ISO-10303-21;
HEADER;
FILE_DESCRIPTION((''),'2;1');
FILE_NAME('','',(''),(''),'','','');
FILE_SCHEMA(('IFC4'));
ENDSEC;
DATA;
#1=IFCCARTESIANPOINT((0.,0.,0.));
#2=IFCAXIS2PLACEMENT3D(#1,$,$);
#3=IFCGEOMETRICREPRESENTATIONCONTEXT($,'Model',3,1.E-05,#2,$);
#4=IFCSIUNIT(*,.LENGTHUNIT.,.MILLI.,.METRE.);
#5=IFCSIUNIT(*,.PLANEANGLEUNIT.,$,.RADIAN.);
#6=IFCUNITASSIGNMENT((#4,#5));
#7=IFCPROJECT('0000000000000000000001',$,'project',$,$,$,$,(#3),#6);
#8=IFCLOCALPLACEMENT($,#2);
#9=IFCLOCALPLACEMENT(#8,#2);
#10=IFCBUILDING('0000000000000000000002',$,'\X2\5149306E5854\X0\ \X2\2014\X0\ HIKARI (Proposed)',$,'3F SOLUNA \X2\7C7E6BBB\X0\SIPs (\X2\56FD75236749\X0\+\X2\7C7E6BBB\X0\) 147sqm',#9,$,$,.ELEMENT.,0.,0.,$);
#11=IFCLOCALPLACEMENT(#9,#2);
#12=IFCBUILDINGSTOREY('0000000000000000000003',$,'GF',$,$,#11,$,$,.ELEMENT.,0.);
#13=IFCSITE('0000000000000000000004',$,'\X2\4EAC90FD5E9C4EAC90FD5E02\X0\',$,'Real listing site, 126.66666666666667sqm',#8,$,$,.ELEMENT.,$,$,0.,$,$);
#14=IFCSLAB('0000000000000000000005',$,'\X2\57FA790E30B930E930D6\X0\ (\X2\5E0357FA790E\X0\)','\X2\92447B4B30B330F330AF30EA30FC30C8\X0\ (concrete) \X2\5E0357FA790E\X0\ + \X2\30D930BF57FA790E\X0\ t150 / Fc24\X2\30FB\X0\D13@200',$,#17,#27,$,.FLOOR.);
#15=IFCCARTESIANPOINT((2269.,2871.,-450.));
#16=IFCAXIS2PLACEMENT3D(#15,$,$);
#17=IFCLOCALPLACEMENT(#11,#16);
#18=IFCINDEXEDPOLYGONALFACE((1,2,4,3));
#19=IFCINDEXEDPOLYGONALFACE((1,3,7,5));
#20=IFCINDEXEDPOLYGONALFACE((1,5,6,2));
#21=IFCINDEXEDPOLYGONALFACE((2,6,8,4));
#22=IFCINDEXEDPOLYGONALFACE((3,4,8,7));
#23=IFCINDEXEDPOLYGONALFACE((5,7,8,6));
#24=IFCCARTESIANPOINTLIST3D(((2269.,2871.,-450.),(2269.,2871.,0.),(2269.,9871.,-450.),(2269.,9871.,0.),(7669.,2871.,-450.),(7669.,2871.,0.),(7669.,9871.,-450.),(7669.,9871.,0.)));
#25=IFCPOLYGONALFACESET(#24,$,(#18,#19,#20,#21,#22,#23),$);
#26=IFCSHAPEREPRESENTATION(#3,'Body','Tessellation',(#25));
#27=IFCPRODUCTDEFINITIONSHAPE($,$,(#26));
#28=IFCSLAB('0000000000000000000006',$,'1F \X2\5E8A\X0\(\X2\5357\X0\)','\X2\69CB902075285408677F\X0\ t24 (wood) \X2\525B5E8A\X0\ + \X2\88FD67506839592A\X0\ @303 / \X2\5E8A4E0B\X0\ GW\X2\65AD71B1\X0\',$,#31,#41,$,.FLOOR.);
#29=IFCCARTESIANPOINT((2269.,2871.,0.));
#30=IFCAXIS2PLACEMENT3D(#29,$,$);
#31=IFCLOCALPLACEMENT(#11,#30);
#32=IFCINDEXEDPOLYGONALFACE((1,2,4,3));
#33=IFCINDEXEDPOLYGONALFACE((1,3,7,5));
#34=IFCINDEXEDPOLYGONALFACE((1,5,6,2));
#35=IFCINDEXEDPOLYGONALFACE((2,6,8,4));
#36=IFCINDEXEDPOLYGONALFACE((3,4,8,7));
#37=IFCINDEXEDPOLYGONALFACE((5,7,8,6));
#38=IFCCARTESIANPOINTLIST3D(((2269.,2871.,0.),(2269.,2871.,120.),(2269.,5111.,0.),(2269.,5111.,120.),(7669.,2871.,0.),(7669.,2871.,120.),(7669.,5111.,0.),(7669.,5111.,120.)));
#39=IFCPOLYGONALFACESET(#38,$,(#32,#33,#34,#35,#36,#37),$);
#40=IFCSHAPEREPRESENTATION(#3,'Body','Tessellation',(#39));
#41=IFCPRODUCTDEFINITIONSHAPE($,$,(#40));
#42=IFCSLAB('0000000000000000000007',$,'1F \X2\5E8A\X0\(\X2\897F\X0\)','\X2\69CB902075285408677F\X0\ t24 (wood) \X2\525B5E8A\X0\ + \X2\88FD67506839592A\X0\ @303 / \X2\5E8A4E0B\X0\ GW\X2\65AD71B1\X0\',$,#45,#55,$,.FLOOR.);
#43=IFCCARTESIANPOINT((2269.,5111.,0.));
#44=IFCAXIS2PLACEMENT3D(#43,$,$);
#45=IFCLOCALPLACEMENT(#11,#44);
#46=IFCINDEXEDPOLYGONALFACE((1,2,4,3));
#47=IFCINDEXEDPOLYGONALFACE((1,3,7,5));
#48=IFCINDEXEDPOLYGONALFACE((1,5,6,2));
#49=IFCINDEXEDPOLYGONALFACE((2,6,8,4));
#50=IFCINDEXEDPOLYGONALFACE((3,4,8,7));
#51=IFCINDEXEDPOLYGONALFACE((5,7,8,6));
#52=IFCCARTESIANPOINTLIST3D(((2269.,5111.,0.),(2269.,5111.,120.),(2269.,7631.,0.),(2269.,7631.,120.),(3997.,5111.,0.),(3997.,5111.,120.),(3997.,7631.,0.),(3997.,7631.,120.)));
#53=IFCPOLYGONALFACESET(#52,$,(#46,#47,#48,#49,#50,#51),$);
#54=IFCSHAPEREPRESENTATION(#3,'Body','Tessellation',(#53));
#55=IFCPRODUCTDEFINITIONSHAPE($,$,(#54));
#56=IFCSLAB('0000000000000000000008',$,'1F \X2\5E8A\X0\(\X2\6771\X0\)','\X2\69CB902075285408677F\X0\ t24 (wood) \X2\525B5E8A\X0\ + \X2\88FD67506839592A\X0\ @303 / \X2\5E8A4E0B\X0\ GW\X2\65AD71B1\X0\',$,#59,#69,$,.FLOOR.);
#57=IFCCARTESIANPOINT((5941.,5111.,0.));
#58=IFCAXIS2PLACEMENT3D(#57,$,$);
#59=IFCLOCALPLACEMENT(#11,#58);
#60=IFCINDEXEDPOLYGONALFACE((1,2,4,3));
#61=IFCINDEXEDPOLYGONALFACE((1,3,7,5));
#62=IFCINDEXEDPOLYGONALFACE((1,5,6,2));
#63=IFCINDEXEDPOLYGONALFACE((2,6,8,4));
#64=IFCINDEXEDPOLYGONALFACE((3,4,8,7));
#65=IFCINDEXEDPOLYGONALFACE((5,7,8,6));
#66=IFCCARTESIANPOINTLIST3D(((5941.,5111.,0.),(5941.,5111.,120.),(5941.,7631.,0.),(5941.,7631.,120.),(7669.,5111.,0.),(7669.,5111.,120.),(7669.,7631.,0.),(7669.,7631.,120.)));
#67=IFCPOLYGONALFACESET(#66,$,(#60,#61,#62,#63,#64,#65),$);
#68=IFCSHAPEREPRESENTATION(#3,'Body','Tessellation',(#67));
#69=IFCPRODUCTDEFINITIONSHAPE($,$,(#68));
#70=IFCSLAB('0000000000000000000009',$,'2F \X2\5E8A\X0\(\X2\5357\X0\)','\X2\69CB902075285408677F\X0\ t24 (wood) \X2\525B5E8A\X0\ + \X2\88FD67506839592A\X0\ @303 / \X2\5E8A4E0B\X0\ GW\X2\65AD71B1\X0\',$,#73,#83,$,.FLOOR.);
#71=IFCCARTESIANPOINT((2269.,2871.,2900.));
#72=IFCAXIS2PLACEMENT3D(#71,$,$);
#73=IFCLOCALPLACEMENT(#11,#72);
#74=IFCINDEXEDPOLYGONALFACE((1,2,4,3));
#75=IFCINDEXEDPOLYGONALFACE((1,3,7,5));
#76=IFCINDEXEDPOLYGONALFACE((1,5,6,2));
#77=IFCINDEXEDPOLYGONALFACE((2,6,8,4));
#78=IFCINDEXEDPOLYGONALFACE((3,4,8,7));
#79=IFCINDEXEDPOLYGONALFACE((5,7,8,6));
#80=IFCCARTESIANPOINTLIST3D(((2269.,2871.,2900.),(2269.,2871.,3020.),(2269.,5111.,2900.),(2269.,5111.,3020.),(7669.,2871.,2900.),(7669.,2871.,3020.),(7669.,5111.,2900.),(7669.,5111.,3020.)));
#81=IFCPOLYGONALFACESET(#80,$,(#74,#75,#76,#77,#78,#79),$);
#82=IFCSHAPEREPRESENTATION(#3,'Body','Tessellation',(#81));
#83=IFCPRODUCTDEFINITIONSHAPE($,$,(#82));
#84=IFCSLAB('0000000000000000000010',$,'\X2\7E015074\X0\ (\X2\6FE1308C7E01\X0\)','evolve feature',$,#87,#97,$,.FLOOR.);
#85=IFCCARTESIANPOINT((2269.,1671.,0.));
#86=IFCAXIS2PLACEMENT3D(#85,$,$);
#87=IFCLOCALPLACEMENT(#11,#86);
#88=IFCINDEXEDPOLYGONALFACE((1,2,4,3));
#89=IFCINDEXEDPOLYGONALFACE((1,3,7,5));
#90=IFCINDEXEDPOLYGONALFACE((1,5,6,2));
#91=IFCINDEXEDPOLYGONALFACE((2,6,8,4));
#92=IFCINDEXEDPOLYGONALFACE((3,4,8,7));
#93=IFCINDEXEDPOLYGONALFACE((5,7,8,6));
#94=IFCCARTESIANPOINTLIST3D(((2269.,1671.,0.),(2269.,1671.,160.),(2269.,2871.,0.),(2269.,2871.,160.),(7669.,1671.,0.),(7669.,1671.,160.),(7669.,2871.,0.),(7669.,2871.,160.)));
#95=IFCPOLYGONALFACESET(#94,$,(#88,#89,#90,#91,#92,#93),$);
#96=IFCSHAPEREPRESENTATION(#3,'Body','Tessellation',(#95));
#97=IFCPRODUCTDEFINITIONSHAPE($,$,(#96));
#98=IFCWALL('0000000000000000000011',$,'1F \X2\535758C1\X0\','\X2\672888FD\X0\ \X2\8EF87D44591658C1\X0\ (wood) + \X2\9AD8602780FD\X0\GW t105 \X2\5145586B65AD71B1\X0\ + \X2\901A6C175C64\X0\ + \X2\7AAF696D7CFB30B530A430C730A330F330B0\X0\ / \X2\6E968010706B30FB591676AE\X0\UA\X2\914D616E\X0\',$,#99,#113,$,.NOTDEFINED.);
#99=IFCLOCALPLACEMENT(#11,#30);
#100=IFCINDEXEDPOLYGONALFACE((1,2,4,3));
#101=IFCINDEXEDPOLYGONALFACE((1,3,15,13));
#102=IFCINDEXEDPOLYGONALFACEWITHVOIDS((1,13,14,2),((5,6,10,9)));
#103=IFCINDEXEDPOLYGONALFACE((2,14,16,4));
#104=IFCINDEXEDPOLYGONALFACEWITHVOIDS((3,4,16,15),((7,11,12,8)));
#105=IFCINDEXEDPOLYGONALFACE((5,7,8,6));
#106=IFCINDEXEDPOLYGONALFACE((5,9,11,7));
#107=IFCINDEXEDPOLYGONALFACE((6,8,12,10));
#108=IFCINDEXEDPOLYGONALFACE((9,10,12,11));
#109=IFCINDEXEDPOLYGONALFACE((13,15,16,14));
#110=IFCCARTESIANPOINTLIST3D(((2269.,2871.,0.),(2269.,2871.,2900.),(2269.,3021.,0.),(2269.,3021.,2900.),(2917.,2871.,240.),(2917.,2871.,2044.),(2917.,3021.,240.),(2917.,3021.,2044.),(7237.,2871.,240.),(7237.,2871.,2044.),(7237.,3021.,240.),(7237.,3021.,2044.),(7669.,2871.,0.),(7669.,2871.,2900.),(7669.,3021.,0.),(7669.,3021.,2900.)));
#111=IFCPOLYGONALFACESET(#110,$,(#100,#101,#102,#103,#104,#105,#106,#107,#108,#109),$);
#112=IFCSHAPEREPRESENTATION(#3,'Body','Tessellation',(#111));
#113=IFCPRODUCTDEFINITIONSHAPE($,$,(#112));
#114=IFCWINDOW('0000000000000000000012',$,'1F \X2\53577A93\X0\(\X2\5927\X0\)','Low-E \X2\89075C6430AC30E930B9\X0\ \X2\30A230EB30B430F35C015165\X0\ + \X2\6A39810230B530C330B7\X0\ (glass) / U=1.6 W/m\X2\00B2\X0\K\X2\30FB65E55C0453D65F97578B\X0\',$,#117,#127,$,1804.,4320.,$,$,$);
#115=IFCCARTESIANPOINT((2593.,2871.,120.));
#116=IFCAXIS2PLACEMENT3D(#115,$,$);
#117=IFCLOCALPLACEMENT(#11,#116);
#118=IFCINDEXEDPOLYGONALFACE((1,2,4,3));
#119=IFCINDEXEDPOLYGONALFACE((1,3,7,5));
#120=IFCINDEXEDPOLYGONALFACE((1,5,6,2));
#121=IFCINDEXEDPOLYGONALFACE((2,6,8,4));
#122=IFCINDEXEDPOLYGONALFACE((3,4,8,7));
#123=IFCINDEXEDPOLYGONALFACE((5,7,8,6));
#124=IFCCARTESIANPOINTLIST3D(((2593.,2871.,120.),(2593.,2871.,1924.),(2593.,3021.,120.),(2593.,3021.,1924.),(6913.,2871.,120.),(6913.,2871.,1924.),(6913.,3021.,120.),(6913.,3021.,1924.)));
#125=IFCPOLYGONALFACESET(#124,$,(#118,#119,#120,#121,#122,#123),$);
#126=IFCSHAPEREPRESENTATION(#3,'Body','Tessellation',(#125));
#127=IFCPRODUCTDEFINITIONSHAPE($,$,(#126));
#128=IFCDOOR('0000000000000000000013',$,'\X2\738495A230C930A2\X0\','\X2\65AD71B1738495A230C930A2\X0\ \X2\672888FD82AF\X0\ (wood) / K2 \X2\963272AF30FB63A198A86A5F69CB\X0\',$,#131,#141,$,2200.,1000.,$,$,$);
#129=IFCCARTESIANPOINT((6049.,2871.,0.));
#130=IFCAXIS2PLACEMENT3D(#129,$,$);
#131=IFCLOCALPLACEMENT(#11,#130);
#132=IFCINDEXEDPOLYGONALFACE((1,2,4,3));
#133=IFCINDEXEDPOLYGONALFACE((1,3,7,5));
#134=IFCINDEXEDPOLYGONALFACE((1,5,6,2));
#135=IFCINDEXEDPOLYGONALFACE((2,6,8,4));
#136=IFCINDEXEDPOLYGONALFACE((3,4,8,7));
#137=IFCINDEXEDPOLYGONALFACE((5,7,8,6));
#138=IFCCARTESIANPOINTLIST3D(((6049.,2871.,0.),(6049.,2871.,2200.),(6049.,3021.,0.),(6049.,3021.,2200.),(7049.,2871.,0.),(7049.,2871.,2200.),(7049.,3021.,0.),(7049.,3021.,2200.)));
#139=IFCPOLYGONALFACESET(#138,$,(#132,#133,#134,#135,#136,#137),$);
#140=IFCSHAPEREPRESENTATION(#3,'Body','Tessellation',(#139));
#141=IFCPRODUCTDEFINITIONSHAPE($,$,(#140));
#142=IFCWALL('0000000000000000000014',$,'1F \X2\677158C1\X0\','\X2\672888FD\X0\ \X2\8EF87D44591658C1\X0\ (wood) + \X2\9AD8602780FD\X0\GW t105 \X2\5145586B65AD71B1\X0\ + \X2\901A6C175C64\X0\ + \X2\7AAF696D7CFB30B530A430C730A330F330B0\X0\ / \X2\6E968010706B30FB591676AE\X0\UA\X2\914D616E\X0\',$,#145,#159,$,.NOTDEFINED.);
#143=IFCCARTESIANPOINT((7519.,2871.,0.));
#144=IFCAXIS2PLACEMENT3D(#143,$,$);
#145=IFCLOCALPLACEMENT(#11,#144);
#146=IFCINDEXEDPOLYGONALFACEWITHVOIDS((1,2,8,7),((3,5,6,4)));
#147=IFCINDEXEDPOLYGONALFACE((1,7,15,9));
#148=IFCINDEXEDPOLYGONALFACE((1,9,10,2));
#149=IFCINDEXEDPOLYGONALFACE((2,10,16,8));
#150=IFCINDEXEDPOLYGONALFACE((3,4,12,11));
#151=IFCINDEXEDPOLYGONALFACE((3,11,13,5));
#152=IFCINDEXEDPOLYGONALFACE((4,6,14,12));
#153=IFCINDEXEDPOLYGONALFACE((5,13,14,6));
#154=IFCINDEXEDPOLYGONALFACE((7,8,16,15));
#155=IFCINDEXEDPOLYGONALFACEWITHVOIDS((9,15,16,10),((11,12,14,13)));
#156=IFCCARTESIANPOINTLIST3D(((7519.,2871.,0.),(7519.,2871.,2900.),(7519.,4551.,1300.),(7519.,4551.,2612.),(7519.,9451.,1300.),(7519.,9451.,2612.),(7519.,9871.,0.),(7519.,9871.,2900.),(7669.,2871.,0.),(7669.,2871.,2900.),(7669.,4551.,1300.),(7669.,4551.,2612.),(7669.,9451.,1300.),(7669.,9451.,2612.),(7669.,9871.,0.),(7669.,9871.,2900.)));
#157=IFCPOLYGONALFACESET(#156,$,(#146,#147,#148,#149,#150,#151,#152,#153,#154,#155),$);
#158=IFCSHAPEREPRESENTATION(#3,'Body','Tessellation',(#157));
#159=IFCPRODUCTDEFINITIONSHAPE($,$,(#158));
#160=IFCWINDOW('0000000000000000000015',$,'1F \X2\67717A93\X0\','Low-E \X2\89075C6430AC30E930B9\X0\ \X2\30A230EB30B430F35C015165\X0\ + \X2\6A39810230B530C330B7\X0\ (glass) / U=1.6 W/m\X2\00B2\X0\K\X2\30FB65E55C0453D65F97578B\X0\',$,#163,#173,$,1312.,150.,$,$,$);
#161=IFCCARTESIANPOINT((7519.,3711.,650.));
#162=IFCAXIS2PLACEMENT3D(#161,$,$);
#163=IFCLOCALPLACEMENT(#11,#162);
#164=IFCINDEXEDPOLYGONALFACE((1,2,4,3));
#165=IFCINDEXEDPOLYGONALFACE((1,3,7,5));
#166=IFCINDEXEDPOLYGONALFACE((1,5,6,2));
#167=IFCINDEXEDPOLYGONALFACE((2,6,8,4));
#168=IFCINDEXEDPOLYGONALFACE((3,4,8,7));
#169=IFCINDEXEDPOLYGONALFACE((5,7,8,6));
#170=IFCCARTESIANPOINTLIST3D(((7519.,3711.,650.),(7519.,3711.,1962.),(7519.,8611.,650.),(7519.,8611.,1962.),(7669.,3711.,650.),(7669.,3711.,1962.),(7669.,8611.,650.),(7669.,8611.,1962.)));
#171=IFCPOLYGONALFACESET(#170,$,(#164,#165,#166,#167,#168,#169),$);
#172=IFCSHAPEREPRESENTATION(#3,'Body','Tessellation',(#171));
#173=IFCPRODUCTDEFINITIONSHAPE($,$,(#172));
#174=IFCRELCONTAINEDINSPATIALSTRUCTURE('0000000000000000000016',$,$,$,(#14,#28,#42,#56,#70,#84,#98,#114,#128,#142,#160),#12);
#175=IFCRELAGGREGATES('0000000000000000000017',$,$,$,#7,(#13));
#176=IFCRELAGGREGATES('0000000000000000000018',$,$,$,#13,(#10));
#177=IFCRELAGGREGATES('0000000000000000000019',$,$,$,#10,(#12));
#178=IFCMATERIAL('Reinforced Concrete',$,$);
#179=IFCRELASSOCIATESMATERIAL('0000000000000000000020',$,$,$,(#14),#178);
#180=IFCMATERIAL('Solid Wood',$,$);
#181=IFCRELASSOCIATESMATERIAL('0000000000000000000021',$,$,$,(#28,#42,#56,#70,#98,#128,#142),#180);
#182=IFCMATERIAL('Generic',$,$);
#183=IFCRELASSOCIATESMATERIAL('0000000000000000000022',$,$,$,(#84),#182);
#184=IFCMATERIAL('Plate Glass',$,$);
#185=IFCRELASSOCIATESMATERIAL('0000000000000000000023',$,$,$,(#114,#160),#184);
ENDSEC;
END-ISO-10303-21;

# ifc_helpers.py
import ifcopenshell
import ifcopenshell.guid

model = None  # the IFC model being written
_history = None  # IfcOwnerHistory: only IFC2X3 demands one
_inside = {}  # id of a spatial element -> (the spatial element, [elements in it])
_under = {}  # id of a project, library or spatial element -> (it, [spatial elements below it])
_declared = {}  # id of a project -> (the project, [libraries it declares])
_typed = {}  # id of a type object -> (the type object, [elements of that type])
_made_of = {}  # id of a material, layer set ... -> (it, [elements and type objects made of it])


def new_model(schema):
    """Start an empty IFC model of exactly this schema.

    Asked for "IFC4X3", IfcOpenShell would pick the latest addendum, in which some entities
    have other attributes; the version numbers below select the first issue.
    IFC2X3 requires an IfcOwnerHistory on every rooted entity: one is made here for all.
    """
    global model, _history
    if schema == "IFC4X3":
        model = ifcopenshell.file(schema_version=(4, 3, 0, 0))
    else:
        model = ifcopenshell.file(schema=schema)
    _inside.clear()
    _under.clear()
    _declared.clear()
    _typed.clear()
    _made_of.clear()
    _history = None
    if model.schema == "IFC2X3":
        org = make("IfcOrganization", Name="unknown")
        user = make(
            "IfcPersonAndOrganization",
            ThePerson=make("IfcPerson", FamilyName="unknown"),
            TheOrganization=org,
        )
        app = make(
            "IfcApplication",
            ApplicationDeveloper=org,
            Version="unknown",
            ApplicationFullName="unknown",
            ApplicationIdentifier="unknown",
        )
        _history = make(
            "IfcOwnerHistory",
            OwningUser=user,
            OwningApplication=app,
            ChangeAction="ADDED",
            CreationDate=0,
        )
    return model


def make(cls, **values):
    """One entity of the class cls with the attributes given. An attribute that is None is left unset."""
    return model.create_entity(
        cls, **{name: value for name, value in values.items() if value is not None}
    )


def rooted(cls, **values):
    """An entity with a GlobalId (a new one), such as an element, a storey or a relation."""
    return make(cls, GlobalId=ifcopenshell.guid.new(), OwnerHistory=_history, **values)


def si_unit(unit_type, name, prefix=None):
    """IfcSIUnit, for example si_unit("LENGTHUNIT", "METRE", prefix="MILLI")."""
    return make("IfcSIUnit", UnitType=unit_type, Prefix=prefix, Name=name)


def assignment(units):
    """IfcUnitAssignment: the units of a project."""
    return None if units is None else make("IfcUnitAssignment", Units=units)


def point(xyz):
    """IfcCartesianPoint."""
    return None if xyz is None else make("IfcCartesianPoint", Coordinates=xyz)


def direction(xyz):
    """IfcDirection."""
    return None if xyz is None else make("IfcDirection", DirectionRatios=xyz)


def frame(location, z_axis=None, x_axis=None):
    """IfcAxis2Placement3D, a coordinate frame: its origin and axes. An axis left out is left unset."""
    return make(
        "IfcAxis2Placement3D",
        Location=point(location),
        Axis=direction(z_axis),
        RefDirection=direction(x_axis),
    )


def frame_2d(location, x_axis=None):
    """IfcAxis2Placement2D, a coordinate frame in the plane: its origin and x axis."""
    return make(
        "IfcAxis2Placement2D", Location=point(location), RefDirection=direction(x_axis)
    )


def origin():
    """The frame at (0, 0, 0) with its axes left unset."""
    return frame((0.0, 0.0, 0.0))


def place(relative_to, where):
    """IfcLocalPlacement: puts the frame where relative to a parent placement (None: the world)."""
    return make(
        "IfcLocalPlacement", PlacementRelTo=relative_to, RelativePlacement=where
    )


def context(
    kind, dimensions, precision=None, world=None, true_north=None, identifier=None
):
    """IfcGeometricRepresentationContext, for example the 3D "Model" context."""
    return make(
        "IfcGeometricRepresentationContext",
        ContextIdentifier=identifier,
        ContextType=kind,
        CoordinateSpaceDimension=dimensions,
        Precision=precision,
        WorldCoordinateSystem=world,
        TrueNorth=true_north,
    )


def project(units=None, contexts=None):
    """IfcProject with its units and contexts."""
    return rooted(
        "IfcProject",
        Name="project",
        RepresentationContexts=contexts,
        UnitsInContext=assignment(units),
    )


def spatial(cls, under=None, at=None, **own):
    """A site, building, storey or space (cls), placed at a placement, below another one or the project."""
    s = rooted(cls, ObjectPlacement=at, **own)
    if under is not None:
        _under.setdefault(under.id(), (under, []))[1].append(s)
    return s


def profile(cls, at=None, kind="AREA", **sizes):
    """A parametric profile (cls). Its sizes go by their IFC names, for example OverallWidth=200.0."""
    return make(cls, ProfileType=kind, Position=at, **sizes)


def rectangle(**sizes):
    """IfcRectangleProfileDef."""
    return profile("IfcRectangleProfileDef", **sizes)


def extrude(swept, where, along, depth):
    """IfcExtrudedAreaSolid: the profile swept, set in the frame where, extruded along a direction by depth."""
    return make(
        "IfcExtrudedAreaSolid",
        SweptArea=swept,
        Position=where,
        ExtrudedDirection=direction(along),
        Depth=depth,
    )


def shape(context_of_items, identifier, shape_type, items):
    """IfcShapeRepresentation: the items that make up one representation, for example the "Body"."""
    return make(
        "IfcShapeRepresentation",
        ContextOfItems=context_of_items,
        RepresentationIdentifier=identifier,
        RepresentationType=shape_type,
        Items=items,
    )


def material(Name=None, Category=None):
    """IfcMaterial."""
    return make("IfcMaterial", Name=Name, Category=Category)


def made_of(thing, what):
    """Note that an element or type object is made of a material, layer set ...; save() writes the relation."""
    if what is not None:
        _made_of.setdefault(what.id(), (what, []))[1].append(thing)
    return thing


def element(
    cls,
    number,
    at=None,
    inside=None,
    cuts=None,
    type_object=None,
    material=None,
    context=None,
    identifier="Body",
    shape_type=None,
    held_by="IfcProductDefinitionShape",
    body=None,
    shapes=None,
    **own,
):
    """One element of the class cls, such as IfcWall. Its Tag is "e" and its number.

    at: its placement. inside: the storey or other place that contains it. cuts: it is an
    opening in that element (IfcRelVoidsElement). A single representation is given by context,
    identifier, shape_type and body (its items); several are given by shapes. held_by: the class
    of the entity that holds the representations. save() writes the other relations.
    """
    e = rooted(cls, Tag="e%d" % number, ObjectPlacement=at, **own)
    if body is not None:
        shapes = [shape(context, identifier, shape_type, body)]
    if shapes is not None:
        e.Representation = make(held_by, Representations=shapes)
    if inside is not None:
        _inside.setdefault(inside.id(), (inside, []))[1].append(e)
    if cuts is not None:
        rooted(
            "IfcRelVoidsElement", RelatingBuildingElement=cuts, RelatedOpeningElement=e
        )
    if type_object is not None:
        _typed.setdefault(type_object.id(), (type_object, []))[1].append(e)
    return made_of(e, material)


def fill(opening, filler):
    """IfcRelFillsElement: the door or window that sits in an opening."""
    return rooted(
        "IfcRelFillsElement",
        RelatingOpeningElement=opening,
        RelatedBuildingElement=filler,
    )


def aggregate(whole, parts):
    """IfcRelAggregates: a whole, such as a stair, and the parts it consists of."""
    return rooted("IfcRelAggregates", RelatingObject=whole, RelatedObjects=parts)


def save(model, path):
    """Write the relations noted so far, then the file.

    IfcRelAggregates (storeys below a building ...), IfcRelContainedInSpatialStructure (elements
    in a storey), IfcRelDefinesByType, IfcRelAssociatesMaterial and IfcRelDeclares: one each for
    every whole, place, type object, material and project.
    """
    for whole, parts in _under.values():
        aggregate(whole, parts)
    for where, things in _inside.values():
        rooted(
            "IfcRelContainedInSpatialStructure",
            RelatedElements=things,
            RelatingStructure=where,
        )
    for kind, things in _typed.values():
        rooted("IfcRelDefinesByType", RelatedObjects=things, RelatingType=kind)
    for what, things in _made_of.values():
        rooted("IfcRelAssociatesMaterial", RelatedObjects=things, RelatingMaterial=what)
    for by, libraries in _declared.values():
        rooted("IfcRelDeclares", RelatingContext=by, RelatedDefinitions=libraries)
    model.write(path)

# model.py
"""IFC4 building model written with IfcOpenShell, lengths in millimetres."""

from ifc_helpers import new_model, si_unit, frame, frame_2d, origin, place, context, project, spatial, rectangle, extrude, material, element, fill, save


model = new_model("IFC4")

# Units and contexts
model_context = context("Model", 3, precision=1e-05, world=origin())
ifc_project = project(units=[si_unit("LENGTHUNIT", "METRE", prefix="MILLI"), si_unit("PLANEANGLEUNIT", "RADIAN")], contexts=[model_context])

# Site, building, storey
site_placement = place(None, origin())
site = spatial("IfcSite", under=ifc_project, at=site_placement, Name="京都府京都市", ObjectType="Real listing site, 126.66666666666667sqm", CompositionType="ELEMENT", RefElevation=0.0)
building_placement = place(site_placement, origin())
building = spatial("IfcBuilding", under=site, at=building_placement, Name="光の塔 — HIKARI (Proposed)", ObjectType="3F SOLUNA 籾殻SIPs (国産杉+籾殻) 147sqm", CompositionType="ELEMENT", ElevationOfRefHeight=0.0, ElevationOfTerrain=0.0)
storey_placement = place(building_placement, origin())
storey = spatial("IfcBuildingStorey", under=building, at=storey_placement, Name="GF", CompositionType="ELEMENT", Elevation=0.0)

# Slabs
ifc_material_1 = material(Name="Reinforced Concrete")
slab_1_placement = place(storey_placement, frame((2269.0, 2871.0, -450.0)))
element("IfcSlab", 1, at=slab_1_placement, inside=storey, material=ifc_material_1, Name="基礎スラブ (布基礎)", Description="鉄筋コンクリート (concrete) 布基礎 + ベタ基礎 t150 / Fc24・D13@200", PredefinedType="FLOOR", context=model_context, shape_type="SweptSolid", body=[
    extrude(rectangle(XDim=5400.0, YDim=7000.0, at=frame_2d((2700.0, 3500.0))), frame((2269.0, 2871.0, -450.0)), (0.0, 0.0, 1.0), 450.0),
])
ifc_material_2 = material(Name="Solid Wood")
slab_2_placement = place(storey_placement, frame((2269.0, 2871.0, 0.0)))
element("IfcSlab", 2, at=slab_2_placement, inside=storey, material=ifc_material_2, Name="1F 床(南)", Description="構造用合板 t24 (wood) 剛床 + 製材根太 @303 / 床下 GW断熱", PredefinedType="FLOOR", context=model_context, shape_type="SweptSolid", body=[
    extrude(rectangle(XDim=5400.0, YDim=2240.0, at=frame_2d((2700.0, 1120.0))), frame((2269.0, 2871.0, 0.0)), (0.0, 0.0, 1.0), 120.0),
])
slab_3_placement = place(storey_placement, frame((2269.0, 5111.0, 0.0)))
element("IfcSlab", 3, at=slab_3_placement, inside=storey, material=ifc_material_2, Name="1F 床(西)", Description="構造用合板 t24 (wood) 剛床 + 製材根太 @303 / 床下 GW断熱", PredefinedType="FLOOR", context=model_context, shape_type="SweptSolid", body=[
    extrude(rectangle(XDim=1728.0, YDim=2520.0, at=frame_2d((864.0, 1260.0))), frame((2269.0, 5111.0, 0.0)), (0.0, 0.0, 1.0), 120.0),
])
slab_4_placement = place(storey_placement, frame((5941.0, 5111.0, 0.0)))
element("IfcSlab", 4, at=slab_4_placement, inside=storey, material=ifc_material_2, Name="1F 床(東)", Description="構造用合板 t24 (wood) 剛床 + 製材根太 @303 / 床下 GW断熱", PredefinedType="FLOOR", context=model_context, shape_type="SweptSolid", body=[
    extrude(rectangle(XDim=1728.0, YDim=2520.0, at=frame_2d((864.0, 1260.0))), frame((5941.0, 5111.0, 0.0)), (0.0, 0.0, 1.0), 120.0),
])
slab_5_placement = place(storey_placement, frame((2269.0, 2871.0, 2900.0)))
element("IfcSlab", 5, at=slab_5_placement, inside=storey, material=ifc_material_2, Name="2F 床(南)", Description="構造用合板 t24 (wood) 剛床 + 製材根太 @303 / 床下 GW断熱", PredefinedType="FLOOR", context=model_context, shape_type="SweptSolid", body=[
    extrude(rectangle(XDim=5400.0, YDim=2240.0, at=frame_2d((2700.0, 1120.0))), frame((2269.0, 2871.0, 2900.0)), (0.0, 0.0, 1.0), 120.0),
])
ifc_material_3 = material(Name="Generic")
slab_6_placement = place(storey_placement, frame((2269.0, 1671.0, 0.0)))
element("IfcSlab", 6, at=slab_6_placement, inside=storey, material=ifc_material_3, Name="縁側 (濡れ縁)", Description="evolve feature", PredefinedType="FLOOR", context=model_context, shape_type="SweptSolid", body=[
    extrude(rectangle(XDim=5400.0, YDim=1200.0, at=frame_2d((2700.0, 600.0))), frame((2269.0, 1671.0, 0.0)), (0.0, 0.0, 1.0), 160.0),
])

# Wall, openings, window, door
wall_1_placement = place(storey_placement, frame((2269.0, 2871.0, 0.0)))
wall_1 = element("IfcWall", 7, at=wall_1_placement, inside=storey, material=ifc_material_2, Name="1F 南壁", Description="木製 軸組外壁 (wood) + 高性能GW t105 充填断熱 + 通気層 + 窯業系サイディング / 準耐火・外皮UA配慮", PredefinedType="NOTDEFINED", context=model_context, shape_type="SweptSolid", body=[
    extrude(rectangle(XDim=5400.0, YDim=150.0, at=frame_2d((2700.0, 75.0))), frame((2269.0, 2871.0, 0.0)), (0.0, 0.0, 1.0), 2900.0),
])
opening_1_placement = place(storey_placement, frame((2593.0, 2871.0, 120.0)))
opening_1 = element("IfcOpeningElement", 8, at=opening_1_placement, cuts=wall_1, PredefinedType="NOTDEFINED", context=model_context, shape_type="SweptSolid", body=[
    extrude(rectangle(XDim=4320.0, YDim=150.0, at=frame_2d((2160.0, 75.0))), frame((2593.0, 2871.0, 120.0)), (0.0, 0.0, 1.0), 1804.0),
])
opening_2_placement = place(storey_placement, frame((6049.0, 2871.0, 0.0)))
opening_2 = element("IfcOpeningElement", 9, at=opening_2_placement, cuts=wall_1, PredefinedType="NOTDEFINED", context=model_context, shape_type="SweptSolid", body=[
    extrude(rectangle(XDim=1000.0, YDim=150.0, at=frame_2d((500.0, 75.0))), frame((6049.0, 2871.0, 0.0)), (0.0, 0.0, 1.0), 2200.0),
])
ifc_material_4 = material(Name="Plate Glass")
window_1_placement = place(storey_placement, frame((2593.0, 2871.0, 120.0)))
window_1 = element("IfcWindow", 10, at=window_1_placement, inside=storey, material=ifc_material_4, Name="1F 南窓(大)", Description="Low-E 複層ガラス アルゴン封入 + 樹脂サッシ (glass) / U=1.6 W/m²K・日射取得型", OverallHeight=1804.0, OverallWidth=4320.0, context=model_context, shape_type="SweptSolid", body=[
    extrude(rectangle(XDim=4320.0, YDim=150.0, at=frame_2d((2160.0, 75.0))), frame((2593.0, 2871.0, 120.0)), (0.0, 0.0, 1.0), 1804.0),
])
fill(opening_1, window_1)
door_placement = place(storey_placement, frame((6049.0, 2871.0, 0.0)))
door = element("IfcDoor", 11, at=door_placement, inside=storey, material=ifc_material_2, Name="玄関ドア", Description="断熱玄関ドア 木製芯 (wood) / K2 防犯・採風機構", OverallHeight=2200.0, OverallWidth=1000.0, context=model_context, shape_type="SweptSolid", body=[
    extrude(rectangle(XDim=1000.0, YDim=150.0, at=frame_2d((500.0, 75.0))), frame((6049.0, 2871.0, 0.0)), (0.0, 0.0, 1.0), 2200.0),
])
fill(opening_2, door)

# Wall, opening, window
wall_2_placement = place(storey_placement, frame((7519.0, 2871.0, 0.0)))
wall_2 = element("IfcWall", 12, at=wall_2_placement, inside=storey, material=ifc_material_2, Name="1F 東壁", Description="木製 軸組外壁 (wood) + 高性能GW t105 充填断熱 + 通気層 + 窯業系サイディング / 準耐火・外皮UA配慮", PredefinedType="NOTDEFINED", context=model_context, shape_type="SweptSolid", body=[
    extrude(rectangle(XDim=150.0, YDim=7000.0, at=frame_2d((75.0, 3500.0))), frame((7519.0, 2871.0, 0.0)), (0.0, 0.0, 1.0), 2900.0),
])
opening_3_placement = place(storey_placement, frame((7519.0, 3711.0, 650.0)))
opening_3 = element("IfcOpeningElement", 13, at=opening_3_placement, cuts=wall_2, PredefinedType="NOTDEFINED", context=model_context, shape_type="SweptSolid", body=[
    extrude(rectangle(XDim=150.0, YDim=4900.0, at=frame_2d((75.0, 2450.0))), frame((7519.0, 3711.0, 650.0)), (0.0, 0.0, 1.0), 1312.0),
])
window_2_placement = place(storey_placement, frame((7519.0, 3711.0, 650.0)))
window_2 = element("IfcWindow", 14, at=window_2_placement, inside=storey, material=ifc_material_4, Name="1F 東窓", Description="Low-E 複層ガラス アルゴン封入 + 樹脂サッシ (glass) / U=1.6 W/m²K・日射取得型", OverallHeight=1312.0, OverallWidth=150.0, context=model_context, shape_type="SweptSolid", body=[
    extrude(rectangle(XDim=150.0, YDim=4900.0, at=frame_2d((75.0, 2450.0))), frame((7519.0, 3711.0, 650.0)), (0.0, 0.0, 1.0), 1312.0),
])
fill(opening_3, window_2)

save(model, "model.ifc")
